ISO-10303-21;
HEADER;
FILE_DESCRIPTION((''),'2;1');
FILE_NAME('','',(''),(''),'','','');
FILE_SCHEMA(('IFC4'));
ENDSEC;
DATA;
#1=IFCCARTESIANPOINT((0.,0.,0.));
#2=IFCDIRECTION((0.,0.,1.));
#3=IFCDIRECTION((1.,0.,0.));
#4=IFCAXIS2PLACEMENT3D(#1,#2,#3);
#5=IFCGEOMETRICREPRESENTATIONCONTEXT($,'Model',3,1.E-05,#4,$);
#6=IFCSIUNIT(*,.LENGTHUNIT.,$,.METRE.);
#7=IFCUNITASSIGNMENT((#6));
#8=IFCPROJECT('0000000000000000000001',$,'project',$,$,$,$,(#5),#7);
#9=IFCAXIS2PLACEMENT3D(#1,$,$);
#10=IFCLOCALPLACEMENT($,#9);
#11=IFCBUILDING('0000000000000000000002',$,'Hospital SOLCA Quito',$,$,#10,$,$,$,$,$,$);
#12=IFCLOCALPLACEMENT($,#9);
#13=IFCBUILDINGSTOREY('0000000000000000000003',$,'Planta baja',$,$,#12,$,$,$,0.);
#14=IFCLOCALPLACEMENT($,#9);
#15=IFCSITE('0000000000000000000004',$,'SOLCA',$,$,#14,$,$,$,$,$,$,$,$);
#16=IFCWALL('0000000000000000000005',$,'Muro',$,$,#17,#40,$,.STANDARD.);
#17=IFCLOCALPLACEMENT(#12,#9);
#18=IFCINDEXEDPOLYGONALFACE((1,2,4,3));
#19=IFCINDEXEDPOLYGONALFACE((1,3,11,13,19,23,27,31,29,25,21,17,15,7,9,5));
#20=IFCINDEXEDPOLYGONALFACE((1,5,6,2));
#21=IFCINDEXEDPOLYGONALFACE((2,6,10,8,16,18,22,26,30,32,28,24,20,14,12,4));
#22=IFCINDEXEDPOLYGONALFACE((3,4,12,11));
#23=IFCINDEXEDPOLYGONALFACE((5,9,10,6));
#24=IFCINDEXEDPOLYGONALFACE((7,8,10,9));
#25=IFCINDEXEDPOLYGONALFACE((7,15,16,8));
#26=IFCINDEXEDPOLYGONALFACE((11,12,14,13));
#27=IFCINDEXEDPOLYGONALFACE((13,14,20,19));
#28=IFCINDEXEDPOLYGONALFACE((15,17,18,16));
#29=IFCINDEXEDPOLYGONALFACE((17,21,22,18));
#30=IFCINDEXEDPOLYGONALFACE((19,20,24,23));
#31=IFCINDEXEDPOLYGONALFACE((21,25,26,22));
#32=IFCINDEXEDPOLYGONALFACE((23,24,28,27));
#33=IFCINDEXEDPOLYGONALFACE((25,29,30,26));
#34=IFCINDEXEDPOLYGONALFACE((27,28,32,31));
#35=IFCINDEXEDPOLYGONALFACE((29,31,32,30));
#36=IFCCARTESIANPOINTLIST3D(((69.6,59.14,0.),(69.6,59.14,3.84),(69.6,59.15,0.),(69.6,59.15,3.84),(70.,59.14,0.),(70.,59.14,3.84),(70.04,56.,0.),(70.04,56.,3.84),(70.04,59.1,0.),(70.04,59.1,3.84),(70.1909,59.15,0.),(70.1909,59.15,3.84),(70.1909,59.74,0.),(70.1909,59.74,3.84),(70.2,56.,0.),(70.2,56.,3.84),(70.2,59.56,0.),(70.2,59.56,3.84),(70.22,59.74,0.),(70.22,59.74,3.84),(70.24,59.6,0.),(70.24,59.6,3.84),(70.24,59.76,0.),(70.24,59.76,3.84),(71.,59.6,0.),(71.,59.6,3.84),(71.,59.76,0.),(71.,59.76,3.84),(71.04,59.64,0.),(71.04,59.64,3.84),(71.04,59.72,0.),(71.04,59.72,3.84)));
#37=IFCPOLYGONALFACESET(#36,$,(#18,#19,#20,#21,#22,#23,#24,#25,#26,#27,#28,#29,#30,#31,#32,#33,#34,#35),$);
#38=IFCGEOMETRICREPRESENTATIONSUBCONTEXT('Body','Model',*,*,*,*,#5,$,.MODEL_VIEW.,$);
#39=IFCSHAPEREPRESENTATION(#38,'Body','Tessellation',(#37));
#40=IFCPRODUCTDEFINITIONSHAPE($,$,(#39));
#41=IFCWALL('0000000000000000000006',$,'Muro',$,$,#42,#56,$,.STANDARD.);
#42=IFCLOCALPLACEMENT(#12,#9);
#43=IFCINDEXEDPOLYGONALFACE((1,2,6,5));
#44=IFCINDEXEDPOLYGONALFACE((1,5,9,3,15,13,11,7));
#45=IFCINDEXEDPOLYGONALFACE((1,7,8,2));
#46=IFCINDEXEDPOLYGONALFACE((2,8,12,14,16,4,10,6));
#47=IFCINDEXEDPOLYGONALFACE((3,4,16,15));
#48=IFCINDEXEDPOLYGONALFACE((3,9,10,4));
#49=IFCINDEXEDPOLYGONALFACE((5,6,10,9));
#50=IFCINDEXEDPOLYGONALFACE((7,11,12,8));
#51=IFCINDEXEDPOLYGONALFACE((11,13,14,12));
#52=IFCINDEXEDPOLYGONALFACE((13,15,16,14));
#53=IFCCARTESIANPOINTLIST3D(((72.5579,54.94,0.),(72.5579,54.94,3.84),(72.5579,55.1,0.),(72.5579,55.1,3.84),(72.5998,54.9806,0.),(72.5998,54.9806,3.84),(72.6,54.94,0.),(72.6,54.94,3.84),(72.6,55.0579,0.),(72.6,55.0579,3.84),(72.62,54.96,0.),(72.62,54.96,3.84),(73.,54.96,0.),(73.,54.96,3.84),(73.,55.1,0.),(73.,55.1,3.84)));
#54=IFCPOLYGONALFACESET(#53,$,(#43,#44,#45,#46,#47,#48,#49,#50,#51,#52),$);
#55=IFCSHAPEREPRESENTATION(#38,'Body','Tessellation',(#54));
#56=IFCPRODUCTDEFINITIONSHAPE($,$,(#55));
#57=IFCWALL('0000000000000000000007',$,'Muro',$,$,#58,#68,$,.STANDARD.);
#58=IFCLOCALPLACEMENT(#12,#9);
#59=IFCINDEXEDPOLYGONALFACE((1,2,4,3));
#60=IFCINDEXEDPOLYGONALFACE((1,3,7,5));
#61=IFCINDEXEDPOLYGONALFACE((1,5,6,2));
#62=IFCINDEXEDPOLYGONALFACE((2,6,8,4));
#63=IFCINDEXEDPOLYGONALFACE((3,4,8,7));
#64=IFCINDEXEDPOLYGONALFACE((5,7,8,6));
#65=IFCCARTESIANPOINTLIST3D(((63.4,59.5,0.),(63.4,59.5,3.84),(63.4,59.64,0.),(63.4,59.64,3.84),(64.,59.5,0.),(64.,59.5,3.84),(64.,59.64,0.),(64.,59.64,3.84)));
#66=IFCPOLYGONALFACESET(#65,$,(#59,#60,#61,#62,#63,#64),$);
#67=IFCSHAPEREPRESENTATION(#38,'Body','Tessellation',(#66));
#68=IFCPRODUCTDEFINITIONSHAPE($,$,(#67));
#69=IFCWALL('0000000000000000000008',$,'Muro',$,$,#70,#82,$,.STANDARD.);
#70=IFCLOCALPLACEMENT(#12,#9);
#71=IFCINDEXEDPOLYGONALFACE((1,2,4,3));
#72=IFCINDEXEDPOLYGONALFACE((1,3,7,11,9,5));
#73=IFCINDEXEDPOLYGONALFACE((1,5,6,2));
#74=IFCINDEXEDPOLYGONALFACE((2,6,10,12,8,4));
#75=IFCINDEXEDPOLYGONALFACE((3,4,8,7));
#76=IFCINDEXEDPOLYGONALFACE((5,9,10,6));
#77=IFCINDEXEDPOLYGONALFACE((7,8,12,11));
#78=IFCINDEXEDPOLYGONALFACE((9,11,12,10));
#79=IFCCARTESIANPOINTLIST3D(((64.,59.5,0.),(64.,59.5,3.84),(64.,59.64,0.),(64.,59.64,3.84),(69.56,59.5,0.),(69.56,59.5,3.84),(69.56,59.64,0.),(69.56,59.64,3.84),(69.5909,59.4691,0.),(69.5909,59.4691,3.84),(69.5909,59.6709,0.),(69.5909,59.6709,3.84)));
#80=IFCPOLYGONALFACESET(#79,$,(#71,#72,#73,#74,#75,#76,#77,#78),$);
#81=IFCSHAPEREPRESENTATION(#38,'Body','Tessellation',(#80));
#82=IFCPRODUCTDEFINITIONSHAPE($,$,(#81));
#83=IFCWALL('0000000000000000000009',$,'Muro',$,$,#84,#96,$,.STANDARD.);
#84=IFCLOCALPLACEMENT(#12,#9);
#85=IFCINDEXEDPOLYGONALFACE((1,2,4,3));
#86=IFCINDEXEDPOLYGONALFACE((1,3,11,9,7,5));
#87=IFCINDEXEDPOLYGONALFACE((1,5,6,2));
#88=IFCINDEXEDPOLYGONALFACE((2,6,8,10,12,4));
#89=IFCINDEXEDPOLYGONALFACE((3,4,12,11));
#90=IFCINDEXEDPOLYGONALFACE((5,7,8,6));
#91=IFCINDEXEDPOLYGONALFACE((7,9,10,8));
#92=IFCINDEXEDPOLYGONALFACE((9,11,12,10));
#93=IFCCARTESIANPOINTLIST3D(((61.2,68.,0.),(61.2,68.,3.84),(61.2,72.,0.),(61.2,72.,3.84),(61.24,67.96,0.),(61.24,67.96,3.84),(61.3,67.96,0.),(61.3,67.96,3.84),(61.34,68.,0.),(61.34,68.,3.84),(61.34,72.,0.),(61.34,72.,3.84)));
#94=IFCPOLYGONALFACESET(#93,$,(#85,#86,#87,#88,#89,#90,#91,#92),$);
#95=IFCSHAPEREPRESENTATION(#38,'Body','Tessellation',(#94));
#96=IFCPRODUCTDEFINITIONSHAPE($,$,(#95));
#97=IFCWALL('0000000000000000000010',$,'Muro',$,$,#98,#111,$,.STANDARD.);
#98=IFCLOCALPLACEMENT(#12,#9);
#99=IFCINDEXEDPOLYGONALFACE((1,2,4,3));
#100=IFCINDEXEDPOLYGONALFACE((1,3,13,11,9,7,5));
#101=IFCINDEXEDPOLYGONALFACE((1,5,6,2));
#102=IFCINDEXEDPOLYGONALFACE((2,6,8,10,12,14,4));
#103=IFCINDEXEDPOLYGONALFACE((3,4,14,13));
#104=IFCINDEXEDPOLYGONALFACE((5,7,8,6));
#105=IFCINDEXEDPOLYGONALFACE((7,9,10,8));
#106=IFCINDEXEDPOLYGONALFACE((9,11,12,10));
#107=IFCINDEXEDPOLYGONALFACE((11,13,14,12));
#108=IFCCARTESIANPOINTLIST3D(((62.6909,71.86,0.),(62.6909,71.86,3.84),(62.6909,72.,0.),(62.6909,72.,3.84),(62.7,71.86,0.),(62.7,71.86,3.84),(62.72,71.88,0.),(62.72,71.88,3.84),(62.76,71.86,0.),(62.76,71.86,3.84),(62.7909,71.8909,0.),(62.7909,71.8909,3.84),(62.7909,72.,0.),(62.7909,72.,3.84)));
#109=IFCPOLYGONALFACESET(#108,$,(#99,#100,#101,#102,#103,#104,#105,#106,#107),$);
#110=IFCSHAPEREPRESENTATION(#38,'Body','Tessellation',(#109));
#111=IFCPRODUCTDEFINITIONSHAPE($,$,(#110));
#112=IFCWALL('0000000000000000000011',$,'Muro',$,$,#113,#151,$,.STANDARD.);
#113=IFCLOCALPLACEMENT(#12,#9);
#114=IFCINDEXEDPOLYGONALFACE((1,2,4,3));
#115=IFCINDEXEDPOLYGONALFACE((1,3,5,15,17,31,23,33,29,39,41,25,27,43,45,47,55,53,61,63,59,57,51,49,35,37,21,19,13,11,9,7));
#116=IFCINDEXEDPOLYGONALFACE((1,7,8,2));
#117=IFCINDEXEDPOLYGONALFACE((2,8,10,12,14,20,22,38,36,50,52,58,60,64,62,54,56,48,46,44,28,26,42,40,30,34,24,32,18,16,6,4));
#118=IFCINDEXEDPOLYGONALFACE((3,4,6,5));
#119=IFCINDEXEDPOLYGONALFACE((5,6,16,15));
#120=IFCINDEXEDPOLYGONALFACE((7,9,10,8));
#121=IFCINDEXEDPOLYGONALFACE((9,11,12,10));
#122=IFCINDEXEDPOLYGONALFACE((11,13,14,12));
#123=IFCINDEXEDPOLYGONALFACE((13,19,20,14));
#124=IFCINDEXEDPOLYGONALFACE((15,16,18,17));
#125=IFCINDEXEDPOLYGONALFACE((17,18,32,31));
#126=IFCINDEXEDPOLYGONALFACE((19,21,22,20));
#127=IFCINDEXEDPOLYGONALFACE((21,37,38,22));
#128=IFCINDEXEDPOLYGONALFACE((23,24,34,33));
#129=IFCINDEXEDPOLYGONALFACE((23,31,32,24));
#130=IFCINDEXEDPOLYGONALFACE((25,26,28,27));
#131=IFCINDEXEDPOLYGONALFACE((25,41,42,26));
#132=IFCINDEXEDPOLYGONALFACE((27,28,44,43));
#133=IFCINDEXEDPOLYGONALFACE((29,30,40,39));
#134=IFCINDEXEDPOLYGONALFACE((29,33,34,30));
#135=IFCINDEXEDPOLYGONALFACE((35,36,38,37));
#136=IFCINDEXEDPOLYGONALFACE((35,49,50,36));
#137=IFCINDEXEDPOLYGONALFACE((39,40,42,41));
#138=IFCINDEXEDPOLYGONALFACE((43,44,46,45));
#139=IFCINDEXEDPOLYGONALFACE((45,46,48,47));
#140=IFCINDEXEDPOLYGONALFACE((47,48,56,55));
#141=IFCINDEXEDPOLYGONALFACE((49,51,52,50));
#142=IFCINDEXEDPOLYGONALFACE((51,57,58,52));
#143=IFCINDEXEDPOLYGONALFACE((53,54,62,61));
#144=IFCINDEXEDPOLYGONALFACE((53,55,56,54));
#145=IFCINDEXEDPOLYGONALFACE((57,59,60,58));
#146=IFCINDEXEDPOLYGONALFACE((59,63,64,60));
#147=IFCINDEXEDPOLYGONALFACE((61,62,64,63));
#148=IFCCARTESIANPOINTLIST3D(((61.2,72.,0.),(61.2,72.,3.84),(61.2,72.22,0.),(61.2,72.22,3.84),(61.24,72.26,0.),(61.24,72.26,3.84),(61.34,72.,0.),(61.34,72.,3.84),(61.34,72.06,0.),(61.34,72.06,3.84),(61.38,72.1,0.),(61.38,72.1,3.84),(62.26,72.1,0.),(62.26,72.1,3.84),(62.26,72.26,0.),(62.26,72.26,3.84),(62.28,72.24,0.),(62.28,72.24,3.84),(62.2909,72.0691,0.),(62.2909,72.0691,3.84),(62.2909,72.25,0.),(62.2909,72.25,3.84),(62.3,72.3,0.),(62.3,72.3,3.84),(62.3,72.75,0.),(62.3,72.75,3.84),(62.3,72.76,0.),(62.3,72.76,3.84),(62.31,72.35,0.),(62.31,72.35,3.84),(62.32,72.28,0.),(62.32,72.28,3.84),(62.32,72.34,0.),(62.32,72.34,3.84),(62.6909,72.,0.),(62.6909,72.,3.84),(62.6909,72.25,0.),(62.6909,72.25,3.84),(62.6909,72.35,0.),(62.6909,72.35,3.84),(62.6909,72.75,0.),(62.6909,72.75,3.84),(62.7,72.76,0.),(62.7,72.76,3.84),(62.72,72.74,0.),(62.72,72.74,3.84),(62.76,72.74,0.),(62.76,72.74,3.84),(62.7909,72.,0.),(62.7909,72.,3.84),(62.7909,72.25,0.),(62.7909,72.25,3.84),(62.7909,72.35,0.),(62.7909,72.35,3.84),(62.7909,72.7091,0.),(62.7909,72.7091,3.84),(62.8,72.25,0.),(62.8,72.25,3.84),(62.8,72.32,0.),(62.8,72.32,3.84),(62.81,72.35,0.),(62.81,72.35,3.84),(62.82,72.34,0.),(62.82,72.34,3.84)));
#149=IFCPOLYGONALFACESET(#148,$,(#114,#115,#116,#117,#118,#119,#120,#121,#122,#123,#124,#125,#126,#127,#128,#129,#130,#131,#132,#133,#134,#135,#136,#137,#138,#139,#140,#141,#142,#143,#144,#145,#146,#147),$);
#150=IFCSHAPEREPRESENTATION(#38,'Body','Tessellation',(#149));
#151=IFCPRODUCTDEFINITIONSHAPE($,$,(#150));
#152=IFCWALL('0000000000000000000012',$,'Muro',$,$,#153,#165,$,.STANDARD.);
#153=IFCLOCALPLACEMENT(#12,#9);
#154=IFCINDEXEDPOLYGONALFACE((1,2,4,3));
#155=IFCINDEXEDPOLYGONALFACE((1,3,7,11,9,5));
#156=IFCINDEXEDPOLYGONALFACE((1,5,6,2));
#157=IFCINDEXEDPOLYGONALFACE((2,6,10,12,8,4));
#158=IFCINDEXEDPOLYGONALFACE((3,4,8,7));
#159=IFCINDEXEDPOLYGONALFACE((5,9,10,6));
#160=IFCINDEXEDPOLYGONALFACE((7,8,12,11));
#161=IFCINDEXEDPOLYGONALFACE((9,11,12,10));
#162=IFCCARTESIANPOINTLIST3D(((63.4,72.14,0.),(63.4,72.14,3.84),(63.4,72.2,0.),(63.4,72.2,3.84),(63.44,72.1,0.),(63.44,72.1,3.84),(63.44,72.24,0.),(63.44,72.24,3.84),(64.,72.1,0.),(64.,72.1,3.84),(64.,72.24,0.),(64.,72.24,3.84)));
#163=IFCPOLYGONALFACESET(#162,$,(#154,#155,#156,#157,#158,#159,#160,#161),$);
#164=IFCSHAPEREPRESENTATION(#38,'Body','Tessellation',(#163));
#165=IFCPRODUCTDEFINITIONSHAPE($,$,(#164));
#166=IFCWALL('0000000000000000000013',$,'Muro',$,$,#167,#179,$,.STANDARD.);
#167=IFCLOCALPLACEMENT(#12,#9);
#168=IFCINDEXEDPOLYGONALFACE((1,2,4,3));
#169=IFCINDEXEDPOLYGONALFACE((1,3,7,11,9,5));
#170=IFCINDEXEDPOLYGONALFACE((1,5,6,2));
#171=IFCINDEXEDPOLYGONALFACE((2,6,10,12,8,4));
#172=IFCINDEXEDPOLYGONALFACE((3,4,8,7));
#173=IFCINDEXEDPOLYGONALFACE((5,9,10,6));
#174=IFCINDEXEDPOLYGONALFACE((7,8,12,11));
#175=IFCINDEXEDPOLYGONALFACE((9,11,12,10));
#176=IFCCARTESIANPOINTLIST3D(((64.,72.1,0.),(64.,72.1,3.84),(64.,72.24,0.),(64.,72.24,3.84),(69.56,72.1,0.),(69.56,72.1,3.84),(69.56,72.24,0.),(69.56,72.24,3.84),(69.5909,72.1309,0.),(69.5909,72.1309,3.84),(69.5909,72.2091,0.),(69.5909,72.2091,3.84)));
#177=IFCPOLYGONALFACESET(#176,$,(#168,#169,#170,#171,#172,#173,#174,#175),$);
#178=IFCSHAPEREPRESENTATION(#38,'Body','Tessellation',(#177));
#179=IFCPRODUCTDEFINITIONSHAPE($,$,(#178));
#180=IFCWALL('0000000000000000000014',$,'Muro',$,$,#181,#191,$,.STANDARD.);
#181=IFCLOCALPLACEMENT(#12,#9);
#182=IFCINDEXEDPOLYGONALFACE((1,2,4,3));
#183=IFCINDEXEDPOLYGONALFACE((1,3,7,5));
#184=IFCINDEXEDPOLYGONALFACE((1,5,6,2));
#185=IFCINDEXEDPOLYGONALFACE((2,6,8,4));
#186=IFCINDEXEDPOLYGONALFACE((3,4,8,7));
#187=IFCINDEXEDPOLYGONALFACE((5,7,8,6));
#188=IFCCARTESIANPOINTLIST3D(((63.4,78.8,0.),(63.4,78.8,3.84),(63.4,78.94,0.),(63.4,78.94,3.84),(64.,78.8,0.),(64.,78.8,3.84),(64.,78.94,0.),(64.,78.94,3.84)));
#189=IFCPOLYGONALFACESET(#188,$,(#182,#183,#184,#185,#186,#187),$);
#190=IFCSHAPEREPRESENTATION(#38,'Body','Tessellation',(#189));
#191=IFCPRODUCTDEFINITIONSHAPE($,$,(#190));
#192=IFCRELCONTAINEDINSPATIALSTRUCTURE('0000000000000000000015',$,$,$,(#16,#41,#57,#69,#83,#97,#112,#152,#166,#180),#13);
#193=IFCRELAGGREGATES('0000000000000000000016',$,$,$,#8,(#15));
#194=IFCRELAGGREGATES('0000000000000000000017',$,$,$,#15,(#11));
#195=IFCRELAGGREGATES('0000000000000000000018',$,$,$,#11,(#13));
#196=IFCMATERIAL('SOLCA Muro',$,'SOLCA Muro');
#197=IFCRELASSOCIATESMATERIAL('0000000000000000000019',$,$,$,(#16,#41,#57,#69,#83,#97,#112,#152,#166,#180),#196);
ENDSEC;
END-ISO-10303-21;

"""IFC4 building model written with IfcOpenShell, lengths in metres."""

from ifc_helpers import new_model, si_unit, origin, origin_with_axes, place, context, subcontext, project, spatial, polyline, outline, extrude, material, element, save


model = new_model("IFC4")

# Units and contexts
model_context = context("Model", 3, precision=1e-05, world=origin_with_axes())
body_context = subcontext(model_context, "Body", "Model", "MODEL_VIEW")
ifc_project = project(units=[si_unit("LENGTHUNIT", "METRE")], contexts=[model_context])

# Site, building, storey
site_placement = place(None, origin())
site = spatial("IfcSite", under=ifc_project, at=site_placement, Name="SOLCA")
building_placement = place(None, origin())
building = spatial("IfcBuilding", under=site, at=building_placement, Name="Hospital SOLCA Quito")
storey_placement = place(None, origin())
storey = spatial("IfcBuildingStorey", under=building, at=storey_placement, Name="Planta baja", Elevation=0.0)

# Walls
ifc_material = material(Name="SOLCA Muro", Category="SOLCA Muro")
wall_1_placement = place(storey_placement, origin_with_axes())
element("IfcWall", 1, at=wall_1_placement, inside=storey, material=ifc_material, Name="Muro", PredefinedType="STANDARD", context=body_context, shape_type="SweptSolid", body=[
    extrude(outline(polyline([(70.04, 59.1), (70.0, 59.14), (69.6, 59.14), (69.6, 59.15), (70.1909, 59.15), (70.1909, 59.74), (70.22, 59.74), (70.24, 59.76), (71.0, 59.76), (71.04, 59.72), (71.04, 59.64), (71.0, 59.6), (70.24, 59.6), (70.2, 59.56), (70.2, 56.0), (70.04, 56.0), (70.04, 59.1)])), origin_with_axes(), (0.0, 0.0, 1.0), 3.84),
])
wall_2_placement = place(storey_placement, origin_with_axes())
element("IfcWall", 2, at=wall_2_placement, inside=storey, material=ifc_material, Name="Muro", PredefinedType="STANDARD", context=body_context, shape_type="SweptSolid", body=[
    extrude(outline(polyline([(72.5579, 54.94), (72.5998, 54.9806), (72.6, 55.0579), (72.5579, 55.1), (73.0, 55.1), (73.0, 54.96), (72.62, 54.96), (72.6, 54.94), (72.5579, 54.94)])), origin_with_axes(), (0.0, 0.0, 1.0), 3.84),
])
wall_3_placement = place(storey_placement, origin_with_axes())
element("IfcWall", 3, at=wall_3_placement, inside=storey, material=ifc_material, Name="Muro", PredefinedType="STANDARD", context=body_context, shape_type="SweptSolid", body=[
    extrude(outline(polyline([(63.4, 59.5), (63.4, 59.64), (64.0, 59.64), (64.0, 59.5), (63.4, 59.5)])), origin_with_axes(), (0.0, 0.0, 1.0), 3.84),
])
wall_4_placement = place(storey_placement, origin_with_axes())
element("IfcWall", 4, at=wall_4_placement, inside=storey, material=ifc_material, Name="Muro", PredefinedType="STANDARD", context=body_context, shape_type="SweptSolid", body=[
    extrude(outline(polyline([(69.5909, 59.4691), (69.56, 59.5), (64.0, 59.5), (64.0, 59.64), (69.56, 59.64), (69.5909, 59.6709), (69.5909, 59.4691)])), origin_with_axes(), (0.0, 0.0, 1.0), 3.84),
])
wall_5_placement = place(storey_placement, origin_with_axes())
element("IfcWall", 5, at=wall_5_placement, inside=storey, material=ifc_material, Name="Muro", PredefinedType="STANDARD", context=body_context, shape_type="SweptSolid", body=[
    extrude(outline(polyline([(61.34, 68.0), (61.3, 67.96), (61.24, 67.96), (61.2, 68.0), (61.2, 72.0), (61.34, 72.0), (61.34, 68.0)])), origin_with_axes(), (0.0, 0.0, 1.0), 3.84),
])
wall_6_placement = place(storey_placement, origin_with_axes())
element("IfcWall", 6, at=wall_6_placement, inside=storey, material=ifc_material, Name="Muro", PredefinedType="STANDARD", context=body_context, shape_type="SweptSolid", body=[
    extrude(outline(polyline([(62.7909, 71.8909), (62.76, 71.86), (62.72, 71.88), (62.7, 71.86), (62.6909, 71.86), (62.6909, 72.0), (62.7909, 72.0), (62.7909, 71.8909)])), origin_with_axes(), (0.0, 0.0, 1.0), 3.84),
])
wall_7_placement = place(storey_placement, origin_with_axes())
element("IfcWall", 7, at=wall_7_placement, inside=storey, material=ifc_material, Name="Muro", PredefinedType="STANDARD", context=body_context, shape_type="SweptSolid", body=[
    extrude(outline(polyline([(61.38, 72.1), (61.34, 72.06), (61.34, 72.0), (61.2, 72.0), (61.2, 72.22), (61.24, 72.26), (62.26, 72.26), (62.28, 72.24), (62.32, 72.28), (62.3, 72.3), (62.32, 72.34), (62.31, 72.35), (62.6909, 72.35), (62.6909, 72.75), (62.3, 72.75), (62.3, 72.76), (62.7, 72.76), (62.72, 72.74), (62.76, 72.74), (62.7909, 72.7091), (62.7909, 72.35), (62.81, 72.35), (62.82, 72.34), (62.8, 72.32), (62.8, 72.25), (62.7909, 72.25), (62.7909, 72.0), (62.6909, 72.0), (62.6909, 72.25), (62.2909, 72.25), (62.2909, 72.0691), (62.26, 72.1), (61.38, 72.1)])), origin_with_axes(), (0.0, 0.0, 1.0), 3.84),
])
wall_8_placement = place(storey_placement, origin_with_axes())
element("IfcWall", 8, at=wall_8_placement, inside=storey, material=ifc_material, Name="Muro", PredefinedType="STANDARD", context=body_context, shape_type="SweptSolid", body=[
    extrude(outline(polyline([(63.44, 72.1), (63.4, 72.14), (63.4, 72.2), (63.44, 72.24), (64.0, 72.24), (64.0, 72.1), (63.44, 72.1)])), origin_with_axes(), (0.0, 0.0, 1.0), 3.84),
])
wall_9_placement = place(storey_placement, origin_with_axes())
element("IfcWall", 9, at=wall_9_placement, inside=storey, material=ifc_material, Name="Muro", PredefinedType="STANDARD", context=body_context, shape_type="SweptSolid", body=[
    extrude(outline(polyline([(69.5909, 72.2091), (69.5909, 72.1309), (69.56, 72.1), (64.0, 72.1), (64.0, 72.24), (69.56, 72.24), (69.5909, 72.2091)])), origin_with_axes(), (0.0, 0.0, 1.0), 3.84),
])
wall_10_placement = place(storey_placement, origin_with_axes())
element("IfcWall", 10, at=wall_10_placement, inside=storey, material=ifc_material, Name="Muro", PredefinedType="STANDARD", context=body_context, shape_type="SweptSolid", body=[
    extrude(outline(polyline([(63.4, 78.8), (63.4, 78.94), (64.0, 78.94), (64.0, 78.8), (63.4, 78.8)])), origin_with_axes(), (0.0, 0.0, 1.0), 3.84),
])

save(model, "model.ifc")
